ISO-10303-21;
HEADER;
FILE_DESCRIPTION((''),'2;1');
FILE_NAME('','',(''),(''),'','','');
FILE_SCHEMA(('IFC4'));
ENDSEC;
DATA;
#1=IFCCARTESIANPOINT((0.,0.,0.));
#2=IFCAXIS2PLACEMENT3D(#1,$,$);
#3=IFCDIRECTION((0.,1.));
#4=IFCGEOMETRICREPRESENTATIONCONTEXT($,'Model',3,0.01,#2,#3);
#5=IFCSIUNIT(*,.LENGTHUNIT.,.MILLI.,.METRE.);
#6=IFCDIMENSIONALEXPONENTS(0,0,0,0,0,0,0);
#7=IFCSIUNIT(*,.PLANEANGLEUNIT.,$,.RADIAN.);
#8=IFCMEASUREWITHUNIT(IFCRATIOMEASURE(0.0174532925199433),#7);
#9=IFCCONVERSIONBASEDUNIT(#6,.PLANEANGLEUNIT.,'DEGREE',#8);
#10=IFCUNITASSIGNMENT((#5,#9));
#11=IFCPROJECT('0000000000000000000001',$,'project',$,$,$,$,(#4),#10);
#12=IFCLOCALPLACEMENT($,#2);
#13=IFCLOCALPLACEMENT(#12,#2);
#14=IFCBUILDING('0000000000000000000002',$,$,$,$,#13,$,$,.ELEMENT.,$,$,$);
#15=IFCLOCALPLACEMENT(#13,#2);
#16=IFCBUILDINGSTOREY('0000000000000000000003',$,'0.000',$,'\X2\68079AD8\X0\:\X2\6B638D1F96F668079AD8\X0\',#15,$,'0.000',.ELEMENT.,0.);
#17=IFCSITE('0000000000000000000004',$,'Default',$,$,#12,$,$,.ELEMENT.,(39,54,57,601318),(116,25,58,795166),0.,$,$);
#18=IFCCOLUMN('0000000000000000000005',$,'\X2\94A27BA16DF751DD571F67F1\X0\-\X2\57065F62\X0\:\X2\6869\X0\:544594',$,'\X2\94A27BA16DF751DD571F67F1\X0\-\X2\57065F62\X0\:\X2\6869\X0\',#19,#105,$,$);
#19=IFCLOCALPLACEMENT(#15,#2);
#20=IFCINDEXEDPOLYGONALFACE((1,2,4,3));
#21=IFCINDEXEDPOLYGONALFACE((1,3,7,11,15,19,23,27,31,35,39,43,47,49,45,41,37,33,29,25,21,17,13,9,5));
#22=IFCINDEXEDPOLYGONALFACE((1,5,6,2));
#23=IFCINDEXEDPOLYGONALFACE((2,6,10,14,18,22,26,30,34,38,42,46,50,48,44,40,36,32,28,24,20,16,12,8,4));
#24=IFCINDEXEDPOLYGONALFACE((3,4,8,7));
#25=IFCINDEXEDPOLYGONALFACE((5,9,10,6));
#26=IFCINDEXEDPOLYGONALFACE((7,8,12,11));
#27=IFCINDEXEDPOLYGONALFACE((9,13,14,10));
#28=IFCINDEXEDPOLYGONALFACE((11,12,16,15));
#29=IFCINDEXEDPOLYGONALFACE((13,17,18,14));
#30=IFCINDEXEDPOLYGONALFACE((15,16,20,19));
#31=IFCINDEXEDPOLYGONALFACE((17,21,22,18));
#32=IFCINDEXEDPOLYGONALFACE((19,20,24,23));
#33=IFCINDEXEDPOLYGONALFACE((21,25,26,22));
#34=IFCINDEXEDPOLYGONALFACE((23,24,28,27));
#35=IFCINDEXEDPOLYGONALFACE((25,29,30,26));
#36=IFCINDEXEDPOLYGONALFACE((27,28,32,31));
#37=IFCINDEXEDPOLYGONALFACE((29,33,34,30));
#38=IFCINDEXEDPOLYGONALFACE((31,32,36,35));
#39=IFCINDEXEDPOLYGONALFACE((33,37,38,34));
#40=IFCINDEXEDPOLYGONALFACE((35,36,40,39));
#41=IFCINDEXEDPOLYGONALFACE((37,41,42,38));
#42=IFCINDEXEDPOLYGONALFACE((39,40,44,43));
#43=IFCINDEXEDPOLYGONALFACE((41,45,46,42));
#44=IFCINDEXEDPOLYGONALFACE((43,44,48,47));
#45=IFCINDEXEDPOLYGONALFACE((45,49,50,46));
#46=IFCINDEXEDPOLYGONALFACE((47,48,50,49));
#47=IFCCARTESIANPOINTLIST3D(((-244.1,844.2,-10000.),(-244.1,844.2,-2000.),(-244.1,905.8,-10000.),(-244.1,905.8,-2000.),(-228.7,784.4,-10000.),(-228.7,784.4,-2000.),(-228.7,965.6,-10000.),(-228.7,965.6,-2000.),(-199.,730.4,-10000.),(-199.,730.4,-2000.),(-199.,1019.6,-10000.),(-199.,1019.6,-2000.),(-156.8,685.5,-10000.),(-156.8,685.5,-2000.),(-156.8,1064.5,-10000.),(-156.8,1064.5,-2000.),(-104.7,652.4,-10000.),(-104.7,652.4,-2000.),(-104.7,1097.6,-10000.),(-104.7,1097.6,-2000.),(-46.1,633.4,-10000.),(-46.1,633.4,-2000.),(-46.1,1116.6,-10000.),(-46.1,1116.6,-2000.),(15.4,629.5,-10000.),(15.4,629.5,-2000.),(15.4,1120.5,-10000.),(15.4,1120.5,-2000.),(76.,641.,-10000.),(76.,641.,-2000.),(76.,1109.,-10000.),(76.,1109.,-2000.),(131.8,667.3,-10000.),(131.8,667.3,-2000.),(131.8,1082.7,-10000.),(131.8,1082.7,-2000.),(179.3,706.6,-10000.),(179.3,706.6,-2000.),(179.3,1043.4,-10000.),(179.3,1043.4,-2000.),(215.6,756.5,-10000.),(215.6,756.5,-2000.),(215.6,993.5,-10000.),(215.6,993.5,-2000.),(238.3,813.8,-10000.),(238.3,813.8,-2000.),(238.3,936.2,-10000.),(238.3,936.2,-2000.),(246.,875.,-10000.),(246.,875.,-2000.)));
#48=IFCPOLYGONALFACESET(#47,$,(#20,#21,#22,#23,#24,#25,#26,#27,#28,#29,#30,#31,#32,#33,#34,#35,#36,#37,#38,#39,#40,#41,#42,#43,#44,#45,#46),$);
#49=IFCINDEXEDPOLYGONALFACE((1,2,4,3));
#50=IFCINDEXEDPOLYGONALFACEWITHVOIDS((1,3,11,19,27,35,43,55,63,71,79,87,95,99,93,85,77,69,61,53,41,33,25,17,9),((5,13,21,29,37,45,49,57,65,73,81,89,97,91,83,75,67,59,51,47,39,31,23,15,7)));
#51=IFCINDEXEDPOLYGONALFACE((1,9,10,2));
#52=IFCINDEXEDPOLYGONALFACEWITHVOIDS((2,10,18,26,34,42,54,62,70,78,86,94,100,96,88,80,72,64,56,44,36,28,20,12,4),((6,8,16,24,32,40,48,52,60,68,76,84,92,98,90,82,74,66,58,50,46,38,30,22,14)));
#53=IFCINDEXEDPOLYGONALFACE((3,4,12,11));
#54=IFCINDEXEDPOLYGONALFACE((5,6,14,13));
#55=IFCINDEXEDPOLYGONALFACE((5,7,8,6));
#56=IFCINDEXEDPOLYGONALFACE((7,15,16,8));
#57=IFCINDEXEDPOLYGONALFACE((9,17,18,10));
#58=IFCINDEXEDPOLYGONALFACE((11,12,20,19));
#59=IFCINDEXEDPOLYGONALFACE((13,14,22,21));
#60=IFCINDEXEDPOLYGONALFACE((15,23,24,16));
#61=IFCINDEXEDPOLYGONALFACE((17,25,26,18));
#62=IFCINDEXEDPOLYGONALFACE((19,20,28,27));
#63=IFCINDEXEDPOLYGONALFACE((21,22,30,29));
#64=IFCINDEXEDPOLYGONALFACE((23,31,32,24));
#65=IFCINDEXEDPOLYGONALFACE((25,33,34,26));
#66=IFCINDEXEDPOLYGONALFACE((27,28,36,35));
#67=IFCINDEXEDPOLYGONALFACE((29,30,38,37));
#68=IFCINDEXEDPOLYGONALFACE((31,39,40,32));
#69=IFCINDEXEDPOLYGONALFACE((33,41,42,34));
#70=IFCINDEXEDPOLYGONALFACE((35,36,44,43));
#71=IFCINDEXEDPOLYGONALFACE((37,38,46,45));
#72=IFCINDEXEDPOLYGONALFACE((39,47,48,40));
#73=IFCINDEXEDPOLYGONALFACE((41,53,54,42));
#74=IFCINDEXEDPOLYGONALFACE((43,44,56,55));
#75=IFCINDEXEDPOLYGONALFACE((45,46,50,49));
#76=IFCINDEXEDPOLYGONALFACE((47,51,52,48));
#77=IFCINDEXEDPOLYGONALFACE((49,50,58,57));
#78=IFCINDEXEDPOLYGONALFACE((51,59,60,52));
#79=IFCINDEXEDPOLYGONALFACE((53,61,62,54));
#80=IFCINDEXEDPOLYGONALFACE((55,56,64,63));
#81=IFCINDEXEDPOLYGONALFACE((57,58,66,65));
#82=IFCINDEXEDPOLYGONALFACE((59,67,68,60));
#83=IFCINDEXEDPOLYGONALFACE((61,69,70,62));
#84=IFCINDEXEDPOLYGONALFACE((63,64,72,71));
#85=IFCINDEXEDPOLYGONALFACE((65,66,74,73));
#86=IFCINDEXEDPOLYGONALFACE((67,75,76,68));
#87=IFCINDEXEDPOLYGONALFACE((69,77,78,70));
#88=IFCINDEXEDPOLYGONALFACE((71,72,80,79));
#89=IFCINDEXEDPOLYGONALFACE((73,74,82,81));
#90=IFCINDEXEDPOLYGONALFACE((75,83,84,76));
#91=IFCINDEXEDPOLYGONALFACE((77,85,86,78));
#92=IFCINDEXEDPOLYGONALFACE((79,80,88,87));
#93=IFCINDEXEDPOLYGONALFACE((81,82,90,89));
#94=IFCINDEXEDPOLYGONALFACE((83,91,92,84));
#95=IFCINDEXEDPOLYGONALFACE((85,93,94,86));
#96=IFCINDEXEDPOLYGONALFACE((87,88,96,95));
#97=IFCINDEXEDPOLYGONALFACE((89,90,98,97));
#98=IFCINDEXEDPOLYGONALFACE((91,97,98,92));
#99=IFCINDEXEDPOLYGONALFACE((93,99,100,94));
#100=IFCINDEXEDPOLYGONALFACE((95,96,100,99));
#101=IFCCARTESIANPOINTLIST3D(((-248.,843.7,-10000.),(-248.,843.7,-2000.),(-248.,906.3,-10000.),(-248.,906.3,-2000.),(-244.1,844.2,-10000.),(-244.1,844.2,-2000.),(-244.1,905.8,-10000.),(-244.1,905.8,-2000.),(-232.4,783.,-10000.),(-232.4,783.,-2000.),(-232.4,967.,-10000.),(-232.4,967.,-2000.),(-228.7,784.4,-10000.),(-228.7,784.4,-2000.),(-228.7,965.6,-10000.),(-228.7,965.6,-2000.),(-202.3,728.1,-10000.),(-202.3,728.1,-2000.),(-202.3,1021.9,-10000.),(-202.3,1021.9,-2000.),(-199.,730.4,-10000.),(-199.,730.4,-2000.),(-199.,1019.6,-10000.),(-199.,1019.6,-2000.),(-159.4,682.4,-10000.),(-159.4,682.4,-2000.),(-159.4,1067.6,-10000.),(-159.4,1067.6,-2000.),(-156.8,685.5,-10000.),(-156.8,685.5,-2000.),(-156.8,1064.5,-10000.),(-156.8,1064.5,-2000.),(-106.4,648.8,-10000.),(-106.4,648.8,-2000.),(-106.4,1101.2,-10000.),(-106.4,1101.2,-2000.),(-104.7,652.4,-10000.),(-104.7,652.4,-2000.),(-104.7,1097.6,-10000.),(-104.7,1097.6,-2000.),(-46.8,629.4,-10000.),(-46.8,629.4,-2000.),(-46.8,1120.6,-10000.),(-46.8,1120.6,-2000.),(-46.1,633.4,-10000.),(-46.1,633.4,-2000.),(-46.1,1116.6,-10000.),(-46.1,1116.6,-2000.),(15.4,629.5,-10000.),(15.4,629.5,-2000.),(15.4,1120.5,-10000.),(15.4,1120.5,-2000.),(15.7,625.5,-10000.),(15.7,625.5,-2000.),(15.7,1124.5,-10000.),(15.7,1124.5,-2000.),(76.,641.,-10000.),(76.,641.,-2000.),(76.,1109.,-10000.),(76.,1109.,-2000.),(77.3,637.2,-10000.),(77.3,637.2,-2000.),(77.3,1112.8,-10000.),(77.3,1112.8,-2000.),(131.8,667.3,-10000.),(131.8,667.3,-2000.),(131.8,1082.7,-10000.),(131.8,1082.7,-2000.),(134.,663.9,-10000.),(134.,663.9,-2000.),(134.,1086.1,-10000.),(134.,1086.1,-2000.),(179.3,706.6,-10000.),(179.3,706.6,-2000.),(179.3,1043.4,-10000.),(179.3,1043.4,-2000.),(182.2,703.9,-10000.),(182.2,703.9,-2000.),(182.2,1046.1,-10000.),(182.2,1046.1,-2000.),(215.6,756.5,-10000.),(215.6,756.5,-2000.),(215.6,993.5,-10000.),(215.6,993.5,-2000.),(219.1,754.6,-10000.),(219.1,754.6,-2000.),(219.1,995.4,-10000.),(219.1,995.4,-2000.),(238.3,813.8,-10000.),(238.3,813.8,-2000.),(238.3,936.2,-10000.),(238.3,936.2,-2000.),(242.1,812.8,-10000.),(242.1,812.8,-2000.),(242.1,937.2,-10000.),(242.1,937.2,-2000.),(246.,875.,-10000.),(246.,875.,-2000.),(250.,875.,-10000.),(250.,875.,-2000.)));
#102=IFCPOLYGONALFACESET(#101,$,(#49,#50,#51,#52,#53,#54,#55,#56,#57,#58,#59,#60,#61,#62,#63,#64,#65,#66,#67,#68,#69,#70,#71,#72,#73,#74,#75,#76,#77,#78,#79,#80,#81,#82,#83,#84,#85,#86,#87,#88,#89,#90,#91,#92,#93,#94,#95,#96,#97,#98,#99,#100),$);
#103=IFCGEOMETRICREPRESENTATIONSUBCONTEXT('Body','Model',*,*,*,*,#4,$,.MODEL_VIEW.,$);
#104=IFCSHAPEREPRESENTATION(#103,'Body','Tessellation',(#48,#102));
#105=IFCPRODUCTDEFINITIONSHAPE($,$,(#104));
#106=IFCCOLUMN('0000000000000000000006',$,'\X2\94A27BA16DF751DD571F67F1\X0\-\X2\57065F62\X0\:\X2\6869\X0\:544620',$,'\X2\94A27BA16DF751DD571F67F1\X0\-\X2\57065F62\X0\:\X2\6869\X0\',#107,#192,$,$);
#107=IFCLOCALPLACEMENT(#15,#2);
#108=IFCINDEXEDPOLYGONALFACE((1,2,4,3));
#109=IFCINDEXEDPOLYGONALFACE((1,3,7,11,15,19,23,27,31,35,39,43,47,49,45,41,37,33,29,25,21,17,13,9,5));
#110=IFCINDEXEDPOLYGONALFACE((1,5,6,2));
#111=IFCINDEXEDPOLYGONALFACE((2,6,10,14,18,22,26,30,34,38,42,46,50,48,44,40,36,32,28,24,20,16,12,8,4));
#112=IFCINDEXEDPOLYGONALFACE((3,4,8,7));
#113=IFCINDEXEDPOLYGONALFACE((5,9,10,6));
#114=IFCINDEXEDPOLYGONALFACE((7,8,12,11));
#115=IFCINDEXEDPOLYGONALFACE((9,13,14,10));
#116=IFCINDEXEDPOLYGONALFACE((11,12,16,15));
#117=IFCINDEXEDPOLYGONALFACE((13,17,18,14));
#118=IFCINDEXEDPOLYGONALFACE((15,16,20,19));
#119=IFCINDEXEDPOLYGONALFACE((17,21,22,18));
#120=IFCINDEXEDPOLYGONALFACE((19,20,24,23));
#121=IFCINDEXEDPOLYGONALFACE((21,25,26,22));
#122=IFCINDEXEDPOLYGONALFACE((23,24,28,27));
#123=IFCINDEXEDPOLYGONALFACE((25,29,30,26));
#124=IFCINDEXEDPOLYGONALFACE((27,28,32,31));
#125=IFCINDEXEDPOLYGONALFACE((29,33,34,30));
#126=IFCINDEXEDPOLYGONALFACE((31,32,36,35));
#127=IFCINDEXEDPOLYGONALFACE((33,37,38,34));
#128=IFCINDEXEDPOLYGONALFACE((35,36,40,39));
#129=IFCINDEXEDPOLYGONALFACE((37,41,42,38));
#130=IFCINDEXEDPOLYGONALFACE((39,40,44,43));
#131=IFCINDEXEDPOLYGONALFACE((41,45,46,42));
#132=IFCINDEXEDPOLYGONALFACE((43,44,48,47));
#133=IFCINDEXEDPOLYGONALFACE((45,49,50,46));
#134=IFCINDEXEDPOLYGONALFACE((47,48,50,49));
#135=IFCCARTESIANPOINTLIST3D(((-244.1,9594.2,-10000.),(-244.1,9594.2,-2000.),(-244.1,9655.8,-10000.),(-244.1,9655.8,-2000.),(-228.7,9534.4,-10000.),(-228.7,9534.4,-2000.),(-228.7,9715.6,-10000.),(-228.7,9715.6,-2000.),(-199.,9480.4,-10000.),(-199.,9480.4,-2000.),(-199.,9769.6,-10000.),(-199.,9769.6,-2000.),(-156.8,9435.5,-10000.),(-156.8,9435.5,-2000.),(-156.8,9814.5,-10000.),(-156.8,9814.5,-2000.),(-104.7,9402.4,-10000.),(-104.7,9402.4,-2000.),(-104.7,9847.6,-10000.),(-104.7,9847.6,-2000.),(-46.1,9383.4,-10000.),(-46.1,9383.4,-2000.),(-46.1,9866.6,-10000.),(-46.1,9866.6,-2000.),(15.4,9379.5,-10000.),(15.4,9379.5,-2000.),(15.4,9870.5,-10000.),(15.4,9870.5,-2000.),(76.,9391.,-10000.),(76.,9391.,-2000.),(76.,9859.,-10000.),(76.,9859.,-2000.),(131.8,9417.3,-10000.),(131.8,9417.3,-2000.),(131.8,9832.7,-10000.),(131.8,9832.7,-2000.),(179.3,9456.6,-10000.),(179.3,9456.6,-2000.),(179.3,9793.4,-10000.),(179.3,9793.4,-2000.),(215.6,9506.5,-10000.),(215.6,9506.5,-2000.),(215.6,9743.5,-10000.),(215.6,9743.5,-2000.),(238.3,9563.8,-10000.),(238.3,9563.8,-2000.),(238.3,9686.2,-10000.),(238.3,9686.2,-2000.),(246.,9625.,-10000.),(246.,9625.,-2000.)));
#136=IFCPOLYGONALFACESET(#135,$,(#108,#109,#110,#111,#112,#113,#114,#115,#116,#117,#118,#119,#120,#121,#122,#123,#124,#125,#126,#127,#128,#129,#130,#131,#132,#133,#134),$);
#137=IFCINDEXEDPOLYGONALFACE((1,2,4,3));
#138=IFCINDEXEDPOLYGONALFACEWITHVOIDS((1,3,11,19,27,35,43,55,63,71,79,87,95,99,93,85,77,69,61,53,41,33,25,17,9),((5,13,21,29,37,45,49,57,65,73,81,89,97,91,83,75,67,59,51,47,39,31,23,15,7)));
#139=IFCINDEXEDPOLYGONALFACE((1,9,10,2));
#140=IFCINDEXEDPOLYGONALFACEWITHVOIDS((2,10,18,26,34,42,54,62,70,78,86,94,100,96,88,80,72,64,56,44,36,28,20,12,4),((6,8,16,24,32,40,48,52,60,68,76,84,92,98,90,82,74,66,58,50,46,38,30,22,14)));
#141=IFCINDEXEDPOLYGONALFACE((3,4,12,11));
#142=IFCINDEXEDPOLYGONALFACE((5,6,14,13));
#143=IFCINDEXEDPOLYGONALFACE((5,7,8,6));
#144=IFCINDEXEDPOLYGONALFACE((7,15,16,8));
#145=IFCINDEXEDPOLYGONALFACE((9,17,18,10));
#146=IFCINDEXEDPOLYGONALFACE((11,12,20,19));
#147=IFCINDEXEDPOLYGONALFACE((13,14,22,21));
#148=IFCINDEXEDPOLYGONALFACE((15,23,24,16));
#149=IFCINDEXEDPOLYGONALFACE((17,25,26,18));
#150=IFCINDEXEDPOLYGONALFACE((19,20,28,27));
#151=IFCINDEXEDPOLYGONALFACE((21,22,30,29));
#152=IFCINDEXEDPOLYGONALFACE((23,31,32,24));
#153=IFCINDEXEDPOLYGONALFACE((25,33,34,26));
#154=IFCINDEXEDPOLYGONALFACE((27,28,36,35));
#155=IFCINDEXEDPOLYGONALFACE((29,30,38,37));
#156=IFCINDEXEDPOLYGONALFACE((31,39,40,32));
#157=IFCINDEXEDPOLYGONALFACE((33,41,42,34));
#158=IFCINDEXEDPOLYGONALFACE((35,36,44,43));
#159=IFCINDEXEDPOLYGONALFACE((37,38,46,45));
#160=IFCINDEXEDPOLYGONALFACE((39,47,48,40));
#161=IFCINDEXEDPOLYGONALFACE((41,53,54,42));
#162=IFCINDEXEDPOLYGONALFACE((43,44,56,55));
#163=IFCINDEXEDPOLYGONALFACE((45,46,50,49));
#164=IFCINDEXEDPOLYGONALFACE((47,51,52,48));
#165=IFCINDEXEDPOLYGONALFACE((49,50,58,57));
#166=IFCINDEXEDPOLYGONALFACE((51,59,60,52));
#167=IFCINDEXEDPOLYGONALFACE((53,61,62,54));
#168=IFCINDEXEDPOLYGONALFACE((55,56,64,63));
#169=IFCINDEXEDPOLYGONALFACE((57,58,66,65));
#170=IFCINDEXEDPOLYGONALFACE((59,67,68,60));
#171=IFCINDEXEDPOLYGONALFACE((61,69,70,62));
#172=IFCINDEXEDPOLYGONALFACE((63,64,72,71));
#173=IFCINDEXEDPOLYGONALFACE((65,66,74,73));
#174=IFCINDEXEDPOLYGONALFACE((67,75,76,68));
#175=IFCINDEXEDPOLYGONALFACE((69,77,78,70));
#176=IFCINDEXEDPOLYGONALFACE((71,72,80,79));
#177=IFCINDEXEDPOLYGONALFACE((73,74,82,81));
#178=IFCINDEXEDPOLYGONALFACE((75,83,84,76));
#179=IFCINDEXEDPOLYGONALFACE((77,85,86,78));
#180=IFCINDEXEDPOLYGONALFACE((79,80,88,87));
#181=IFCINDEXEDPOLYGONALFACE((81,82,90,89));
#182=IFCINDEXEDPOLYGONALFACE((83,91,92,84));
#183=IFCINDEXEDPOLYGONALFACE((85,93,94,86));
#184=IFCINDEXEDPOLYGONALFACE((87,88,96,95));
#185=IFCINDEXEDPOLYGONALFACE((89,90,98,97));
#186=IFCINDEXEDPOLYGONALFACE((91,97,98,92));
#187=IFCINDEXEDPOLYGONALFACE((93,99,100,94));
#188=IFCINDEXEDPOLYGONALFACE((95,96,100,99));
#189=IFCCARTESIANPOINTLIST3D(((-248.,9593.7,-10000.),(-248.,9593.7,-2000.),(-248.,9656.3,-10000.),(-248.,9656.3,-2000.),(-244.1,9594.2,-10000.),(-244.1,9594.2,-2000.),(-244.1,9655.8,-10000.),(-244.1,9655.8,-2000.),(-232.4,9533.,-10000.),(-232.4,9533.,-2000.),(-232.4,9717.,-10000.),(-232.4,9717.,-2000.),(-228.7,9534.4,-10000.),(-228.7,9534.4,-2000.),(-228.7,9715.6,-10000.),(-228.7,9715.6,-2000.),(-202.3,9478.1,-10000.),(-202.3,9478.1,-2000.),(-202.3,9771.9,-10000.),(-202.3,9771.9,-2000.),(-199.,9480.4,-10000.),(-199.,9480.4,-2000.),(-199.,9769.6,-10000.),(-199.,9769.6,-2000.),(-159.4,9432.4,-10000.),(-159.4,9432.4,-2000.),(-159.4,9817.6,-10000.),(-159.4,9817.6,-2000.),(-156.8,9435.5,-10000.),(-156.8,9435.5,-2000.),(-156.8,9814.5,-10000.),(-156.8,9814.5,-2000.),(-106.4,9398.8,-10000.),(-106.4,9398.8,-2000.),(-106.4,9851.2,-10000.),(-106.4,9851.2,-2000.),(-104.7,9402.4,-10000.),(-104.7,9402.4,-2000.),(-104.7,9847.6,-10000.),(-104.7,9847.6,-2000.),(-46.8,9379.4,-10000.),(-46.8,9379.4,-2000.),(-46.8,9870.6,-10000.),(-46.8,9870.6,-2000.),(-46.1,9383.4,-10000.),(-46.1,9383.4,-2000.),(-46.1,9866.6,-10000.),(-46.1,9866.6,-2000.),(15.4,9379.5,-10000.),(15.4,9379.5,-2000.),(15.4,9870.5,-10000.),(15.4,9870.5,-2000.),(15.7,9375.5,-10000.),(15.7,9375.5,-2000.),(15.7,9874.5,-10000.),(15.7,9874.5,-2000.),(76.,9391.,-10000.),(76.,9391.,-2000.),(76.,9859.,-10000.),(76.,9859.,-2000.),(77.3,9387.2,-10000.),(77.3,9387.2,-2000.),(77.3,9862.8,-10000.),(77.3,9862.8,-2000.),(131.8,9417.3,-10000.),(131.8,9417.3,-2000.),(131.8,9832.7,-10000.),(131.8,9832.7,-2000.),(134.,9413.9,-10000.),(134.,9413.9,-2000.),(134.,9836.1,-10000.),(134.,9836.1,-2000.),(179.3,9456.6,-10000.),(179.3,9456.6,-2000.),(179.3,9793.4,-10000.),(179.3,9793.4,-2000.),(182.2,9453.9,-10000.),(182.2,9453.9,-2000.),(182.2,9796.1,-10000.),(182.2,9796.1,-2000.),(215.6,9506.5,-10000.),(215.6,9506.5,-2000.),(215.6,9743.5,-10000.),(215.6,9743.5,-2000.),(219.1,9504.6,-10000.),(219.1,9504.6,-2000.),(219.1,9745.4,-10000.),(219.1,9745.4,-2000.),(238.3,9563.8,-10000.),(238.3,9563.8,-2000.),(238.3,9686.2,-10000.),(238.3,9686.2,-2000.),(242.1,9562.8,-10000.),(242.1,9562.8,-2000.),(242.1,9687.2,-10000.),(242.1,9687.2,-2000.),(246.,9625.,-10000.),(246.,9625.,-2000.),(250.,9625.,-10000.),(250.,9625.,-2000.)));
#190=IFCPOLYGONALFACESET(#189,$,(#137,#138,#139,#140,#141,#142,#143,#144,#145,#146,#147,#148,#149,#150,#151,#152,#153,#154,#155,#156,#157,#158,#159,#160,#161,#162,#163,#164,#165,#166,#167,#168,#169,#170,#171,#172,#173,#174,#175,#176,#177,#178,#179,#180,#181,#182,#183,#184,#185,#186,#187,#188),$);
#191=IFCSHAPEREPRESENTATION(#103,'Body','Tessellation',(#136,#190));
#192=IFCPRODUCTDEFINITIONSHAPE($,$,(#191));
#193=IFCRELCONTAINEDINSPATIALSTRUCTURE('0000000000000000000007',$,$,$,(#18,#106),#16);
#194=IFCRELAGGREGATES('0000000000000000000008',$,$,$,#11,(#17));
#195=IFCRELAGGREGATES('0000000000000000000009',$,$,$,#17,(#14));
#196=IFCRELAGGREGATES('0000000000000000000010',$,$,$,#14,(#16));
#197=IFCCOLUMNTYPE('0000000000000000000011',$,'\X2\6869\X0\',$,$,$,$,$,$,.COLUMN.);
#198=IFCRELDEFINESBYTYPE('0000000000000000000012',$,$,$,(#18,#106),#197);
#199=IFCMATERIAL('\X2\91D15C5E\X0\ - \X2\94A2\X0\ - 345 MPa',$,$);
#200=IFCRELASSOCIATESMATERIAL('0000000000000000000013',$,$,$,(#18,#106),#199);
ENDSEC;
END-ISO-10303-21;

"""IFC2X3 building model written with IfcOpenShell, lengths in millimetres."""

from ifc_helpers import new_model, entity, si_unit, converted_unit, direction, frame, frame_2d, origin, place, context, subcontext, project, spatial, circle, hollow_circle, extrude, source, transform, mapped, material, type_object, type_shapes, element, save


model = new_model("IFC2X3")

# Units and contexts
model_context = context("Model", 3, precision=0.01, world=origin(), true_north=direction((0.0, 1.0)))
body_context = subcontext(model_context, "Body", "Model", "MODEL_VIEW")
ifc_project = project(units=[si_unit("LENGTHUNIT", "METRE", prefix="MILLI"), converted_unit("PLANEANGLEUNIT", "DEGREE", entity("IfcRatioMeasure", 0.0174532925199433), si_unit("PLANEANGLEUNIT", "RADIAN"), dimensions=[0, 0, 0, 0, 0, 0, 0])], contexts=[model_context])

# Site, building, storey
site_placement = place(None, origin())
site = spatial("IfcSite", under=ifc_project, at=site_placement, Name="Default", CompositionType="ELEMENT", RefLatitude=(39, 54, 57, 601318), RefLongitude=(116, 25, 58, 795166), RefElevation=0.0)
building_placement = place(site_placement, origin())
building = spatial("IfcBuilding", under=site, at=building_placement, CompositionType="ELEMENT")
storey_placement = place(building_placement, origin())
storey = spatial("IfcBuildingStorey", under=building, at=storey_placement, Name="0.000", ObjectType="标高:正负零标高", LongName="0.000", CompositionType="ELEMENT", Elevation=0.0)

# Columns
ifc_material_1 = material(Name="金属 - 钢 - 345 MPa")
column_type_1 = type_object("IfcColumnType", Name="桩", PredefinedType="COLUMN")
shared_shape_1 = source(origin(), body_context, "Body", "SweptSolid", [
    extrude(circle(Radius=246.0, at=frame_2d((0.0, 0.0), x_axis=(1.0, 0.0))), frame((0.0, 0.0, -10000.0)), (0.0, 0.0, 1.0), 8000.0),
    extrude(hollow_circle(Radius=250.0, WallThickness=4.0, at=frame_2d((0.0, 0.0), x_axis=(1.0, 0.0))), frame((0.0, 0.0, -10000.0)), (0.0, 0.0, 1.0), 8000.0),
])
type_shapes(column_type_1, [shared_shape_1])
for number, where, name in (
    (1, (0.0, 875.0, 0.0), "钢管混凝土柱-圆形:桩:544594"),
    (2, (0.0, 9625.0, 0.0), "钢管混凝土柱-圆形:桩:544620"),
):
    element("IfcColumn", number, at=place(storey_placement, frame(where)), inside=storey, type_object=column_type_1, material=ifc_material_1, Name=name, ObjectType="钢管混凝土柱-圆形:桩", context=body_context, shape_type="MappedRepresentation", body=[
        mapped(shared_shape_1, transform((0.0, 0.0, 0.0), scale=1.0)),
    ])

save(model, "model.ifc")
